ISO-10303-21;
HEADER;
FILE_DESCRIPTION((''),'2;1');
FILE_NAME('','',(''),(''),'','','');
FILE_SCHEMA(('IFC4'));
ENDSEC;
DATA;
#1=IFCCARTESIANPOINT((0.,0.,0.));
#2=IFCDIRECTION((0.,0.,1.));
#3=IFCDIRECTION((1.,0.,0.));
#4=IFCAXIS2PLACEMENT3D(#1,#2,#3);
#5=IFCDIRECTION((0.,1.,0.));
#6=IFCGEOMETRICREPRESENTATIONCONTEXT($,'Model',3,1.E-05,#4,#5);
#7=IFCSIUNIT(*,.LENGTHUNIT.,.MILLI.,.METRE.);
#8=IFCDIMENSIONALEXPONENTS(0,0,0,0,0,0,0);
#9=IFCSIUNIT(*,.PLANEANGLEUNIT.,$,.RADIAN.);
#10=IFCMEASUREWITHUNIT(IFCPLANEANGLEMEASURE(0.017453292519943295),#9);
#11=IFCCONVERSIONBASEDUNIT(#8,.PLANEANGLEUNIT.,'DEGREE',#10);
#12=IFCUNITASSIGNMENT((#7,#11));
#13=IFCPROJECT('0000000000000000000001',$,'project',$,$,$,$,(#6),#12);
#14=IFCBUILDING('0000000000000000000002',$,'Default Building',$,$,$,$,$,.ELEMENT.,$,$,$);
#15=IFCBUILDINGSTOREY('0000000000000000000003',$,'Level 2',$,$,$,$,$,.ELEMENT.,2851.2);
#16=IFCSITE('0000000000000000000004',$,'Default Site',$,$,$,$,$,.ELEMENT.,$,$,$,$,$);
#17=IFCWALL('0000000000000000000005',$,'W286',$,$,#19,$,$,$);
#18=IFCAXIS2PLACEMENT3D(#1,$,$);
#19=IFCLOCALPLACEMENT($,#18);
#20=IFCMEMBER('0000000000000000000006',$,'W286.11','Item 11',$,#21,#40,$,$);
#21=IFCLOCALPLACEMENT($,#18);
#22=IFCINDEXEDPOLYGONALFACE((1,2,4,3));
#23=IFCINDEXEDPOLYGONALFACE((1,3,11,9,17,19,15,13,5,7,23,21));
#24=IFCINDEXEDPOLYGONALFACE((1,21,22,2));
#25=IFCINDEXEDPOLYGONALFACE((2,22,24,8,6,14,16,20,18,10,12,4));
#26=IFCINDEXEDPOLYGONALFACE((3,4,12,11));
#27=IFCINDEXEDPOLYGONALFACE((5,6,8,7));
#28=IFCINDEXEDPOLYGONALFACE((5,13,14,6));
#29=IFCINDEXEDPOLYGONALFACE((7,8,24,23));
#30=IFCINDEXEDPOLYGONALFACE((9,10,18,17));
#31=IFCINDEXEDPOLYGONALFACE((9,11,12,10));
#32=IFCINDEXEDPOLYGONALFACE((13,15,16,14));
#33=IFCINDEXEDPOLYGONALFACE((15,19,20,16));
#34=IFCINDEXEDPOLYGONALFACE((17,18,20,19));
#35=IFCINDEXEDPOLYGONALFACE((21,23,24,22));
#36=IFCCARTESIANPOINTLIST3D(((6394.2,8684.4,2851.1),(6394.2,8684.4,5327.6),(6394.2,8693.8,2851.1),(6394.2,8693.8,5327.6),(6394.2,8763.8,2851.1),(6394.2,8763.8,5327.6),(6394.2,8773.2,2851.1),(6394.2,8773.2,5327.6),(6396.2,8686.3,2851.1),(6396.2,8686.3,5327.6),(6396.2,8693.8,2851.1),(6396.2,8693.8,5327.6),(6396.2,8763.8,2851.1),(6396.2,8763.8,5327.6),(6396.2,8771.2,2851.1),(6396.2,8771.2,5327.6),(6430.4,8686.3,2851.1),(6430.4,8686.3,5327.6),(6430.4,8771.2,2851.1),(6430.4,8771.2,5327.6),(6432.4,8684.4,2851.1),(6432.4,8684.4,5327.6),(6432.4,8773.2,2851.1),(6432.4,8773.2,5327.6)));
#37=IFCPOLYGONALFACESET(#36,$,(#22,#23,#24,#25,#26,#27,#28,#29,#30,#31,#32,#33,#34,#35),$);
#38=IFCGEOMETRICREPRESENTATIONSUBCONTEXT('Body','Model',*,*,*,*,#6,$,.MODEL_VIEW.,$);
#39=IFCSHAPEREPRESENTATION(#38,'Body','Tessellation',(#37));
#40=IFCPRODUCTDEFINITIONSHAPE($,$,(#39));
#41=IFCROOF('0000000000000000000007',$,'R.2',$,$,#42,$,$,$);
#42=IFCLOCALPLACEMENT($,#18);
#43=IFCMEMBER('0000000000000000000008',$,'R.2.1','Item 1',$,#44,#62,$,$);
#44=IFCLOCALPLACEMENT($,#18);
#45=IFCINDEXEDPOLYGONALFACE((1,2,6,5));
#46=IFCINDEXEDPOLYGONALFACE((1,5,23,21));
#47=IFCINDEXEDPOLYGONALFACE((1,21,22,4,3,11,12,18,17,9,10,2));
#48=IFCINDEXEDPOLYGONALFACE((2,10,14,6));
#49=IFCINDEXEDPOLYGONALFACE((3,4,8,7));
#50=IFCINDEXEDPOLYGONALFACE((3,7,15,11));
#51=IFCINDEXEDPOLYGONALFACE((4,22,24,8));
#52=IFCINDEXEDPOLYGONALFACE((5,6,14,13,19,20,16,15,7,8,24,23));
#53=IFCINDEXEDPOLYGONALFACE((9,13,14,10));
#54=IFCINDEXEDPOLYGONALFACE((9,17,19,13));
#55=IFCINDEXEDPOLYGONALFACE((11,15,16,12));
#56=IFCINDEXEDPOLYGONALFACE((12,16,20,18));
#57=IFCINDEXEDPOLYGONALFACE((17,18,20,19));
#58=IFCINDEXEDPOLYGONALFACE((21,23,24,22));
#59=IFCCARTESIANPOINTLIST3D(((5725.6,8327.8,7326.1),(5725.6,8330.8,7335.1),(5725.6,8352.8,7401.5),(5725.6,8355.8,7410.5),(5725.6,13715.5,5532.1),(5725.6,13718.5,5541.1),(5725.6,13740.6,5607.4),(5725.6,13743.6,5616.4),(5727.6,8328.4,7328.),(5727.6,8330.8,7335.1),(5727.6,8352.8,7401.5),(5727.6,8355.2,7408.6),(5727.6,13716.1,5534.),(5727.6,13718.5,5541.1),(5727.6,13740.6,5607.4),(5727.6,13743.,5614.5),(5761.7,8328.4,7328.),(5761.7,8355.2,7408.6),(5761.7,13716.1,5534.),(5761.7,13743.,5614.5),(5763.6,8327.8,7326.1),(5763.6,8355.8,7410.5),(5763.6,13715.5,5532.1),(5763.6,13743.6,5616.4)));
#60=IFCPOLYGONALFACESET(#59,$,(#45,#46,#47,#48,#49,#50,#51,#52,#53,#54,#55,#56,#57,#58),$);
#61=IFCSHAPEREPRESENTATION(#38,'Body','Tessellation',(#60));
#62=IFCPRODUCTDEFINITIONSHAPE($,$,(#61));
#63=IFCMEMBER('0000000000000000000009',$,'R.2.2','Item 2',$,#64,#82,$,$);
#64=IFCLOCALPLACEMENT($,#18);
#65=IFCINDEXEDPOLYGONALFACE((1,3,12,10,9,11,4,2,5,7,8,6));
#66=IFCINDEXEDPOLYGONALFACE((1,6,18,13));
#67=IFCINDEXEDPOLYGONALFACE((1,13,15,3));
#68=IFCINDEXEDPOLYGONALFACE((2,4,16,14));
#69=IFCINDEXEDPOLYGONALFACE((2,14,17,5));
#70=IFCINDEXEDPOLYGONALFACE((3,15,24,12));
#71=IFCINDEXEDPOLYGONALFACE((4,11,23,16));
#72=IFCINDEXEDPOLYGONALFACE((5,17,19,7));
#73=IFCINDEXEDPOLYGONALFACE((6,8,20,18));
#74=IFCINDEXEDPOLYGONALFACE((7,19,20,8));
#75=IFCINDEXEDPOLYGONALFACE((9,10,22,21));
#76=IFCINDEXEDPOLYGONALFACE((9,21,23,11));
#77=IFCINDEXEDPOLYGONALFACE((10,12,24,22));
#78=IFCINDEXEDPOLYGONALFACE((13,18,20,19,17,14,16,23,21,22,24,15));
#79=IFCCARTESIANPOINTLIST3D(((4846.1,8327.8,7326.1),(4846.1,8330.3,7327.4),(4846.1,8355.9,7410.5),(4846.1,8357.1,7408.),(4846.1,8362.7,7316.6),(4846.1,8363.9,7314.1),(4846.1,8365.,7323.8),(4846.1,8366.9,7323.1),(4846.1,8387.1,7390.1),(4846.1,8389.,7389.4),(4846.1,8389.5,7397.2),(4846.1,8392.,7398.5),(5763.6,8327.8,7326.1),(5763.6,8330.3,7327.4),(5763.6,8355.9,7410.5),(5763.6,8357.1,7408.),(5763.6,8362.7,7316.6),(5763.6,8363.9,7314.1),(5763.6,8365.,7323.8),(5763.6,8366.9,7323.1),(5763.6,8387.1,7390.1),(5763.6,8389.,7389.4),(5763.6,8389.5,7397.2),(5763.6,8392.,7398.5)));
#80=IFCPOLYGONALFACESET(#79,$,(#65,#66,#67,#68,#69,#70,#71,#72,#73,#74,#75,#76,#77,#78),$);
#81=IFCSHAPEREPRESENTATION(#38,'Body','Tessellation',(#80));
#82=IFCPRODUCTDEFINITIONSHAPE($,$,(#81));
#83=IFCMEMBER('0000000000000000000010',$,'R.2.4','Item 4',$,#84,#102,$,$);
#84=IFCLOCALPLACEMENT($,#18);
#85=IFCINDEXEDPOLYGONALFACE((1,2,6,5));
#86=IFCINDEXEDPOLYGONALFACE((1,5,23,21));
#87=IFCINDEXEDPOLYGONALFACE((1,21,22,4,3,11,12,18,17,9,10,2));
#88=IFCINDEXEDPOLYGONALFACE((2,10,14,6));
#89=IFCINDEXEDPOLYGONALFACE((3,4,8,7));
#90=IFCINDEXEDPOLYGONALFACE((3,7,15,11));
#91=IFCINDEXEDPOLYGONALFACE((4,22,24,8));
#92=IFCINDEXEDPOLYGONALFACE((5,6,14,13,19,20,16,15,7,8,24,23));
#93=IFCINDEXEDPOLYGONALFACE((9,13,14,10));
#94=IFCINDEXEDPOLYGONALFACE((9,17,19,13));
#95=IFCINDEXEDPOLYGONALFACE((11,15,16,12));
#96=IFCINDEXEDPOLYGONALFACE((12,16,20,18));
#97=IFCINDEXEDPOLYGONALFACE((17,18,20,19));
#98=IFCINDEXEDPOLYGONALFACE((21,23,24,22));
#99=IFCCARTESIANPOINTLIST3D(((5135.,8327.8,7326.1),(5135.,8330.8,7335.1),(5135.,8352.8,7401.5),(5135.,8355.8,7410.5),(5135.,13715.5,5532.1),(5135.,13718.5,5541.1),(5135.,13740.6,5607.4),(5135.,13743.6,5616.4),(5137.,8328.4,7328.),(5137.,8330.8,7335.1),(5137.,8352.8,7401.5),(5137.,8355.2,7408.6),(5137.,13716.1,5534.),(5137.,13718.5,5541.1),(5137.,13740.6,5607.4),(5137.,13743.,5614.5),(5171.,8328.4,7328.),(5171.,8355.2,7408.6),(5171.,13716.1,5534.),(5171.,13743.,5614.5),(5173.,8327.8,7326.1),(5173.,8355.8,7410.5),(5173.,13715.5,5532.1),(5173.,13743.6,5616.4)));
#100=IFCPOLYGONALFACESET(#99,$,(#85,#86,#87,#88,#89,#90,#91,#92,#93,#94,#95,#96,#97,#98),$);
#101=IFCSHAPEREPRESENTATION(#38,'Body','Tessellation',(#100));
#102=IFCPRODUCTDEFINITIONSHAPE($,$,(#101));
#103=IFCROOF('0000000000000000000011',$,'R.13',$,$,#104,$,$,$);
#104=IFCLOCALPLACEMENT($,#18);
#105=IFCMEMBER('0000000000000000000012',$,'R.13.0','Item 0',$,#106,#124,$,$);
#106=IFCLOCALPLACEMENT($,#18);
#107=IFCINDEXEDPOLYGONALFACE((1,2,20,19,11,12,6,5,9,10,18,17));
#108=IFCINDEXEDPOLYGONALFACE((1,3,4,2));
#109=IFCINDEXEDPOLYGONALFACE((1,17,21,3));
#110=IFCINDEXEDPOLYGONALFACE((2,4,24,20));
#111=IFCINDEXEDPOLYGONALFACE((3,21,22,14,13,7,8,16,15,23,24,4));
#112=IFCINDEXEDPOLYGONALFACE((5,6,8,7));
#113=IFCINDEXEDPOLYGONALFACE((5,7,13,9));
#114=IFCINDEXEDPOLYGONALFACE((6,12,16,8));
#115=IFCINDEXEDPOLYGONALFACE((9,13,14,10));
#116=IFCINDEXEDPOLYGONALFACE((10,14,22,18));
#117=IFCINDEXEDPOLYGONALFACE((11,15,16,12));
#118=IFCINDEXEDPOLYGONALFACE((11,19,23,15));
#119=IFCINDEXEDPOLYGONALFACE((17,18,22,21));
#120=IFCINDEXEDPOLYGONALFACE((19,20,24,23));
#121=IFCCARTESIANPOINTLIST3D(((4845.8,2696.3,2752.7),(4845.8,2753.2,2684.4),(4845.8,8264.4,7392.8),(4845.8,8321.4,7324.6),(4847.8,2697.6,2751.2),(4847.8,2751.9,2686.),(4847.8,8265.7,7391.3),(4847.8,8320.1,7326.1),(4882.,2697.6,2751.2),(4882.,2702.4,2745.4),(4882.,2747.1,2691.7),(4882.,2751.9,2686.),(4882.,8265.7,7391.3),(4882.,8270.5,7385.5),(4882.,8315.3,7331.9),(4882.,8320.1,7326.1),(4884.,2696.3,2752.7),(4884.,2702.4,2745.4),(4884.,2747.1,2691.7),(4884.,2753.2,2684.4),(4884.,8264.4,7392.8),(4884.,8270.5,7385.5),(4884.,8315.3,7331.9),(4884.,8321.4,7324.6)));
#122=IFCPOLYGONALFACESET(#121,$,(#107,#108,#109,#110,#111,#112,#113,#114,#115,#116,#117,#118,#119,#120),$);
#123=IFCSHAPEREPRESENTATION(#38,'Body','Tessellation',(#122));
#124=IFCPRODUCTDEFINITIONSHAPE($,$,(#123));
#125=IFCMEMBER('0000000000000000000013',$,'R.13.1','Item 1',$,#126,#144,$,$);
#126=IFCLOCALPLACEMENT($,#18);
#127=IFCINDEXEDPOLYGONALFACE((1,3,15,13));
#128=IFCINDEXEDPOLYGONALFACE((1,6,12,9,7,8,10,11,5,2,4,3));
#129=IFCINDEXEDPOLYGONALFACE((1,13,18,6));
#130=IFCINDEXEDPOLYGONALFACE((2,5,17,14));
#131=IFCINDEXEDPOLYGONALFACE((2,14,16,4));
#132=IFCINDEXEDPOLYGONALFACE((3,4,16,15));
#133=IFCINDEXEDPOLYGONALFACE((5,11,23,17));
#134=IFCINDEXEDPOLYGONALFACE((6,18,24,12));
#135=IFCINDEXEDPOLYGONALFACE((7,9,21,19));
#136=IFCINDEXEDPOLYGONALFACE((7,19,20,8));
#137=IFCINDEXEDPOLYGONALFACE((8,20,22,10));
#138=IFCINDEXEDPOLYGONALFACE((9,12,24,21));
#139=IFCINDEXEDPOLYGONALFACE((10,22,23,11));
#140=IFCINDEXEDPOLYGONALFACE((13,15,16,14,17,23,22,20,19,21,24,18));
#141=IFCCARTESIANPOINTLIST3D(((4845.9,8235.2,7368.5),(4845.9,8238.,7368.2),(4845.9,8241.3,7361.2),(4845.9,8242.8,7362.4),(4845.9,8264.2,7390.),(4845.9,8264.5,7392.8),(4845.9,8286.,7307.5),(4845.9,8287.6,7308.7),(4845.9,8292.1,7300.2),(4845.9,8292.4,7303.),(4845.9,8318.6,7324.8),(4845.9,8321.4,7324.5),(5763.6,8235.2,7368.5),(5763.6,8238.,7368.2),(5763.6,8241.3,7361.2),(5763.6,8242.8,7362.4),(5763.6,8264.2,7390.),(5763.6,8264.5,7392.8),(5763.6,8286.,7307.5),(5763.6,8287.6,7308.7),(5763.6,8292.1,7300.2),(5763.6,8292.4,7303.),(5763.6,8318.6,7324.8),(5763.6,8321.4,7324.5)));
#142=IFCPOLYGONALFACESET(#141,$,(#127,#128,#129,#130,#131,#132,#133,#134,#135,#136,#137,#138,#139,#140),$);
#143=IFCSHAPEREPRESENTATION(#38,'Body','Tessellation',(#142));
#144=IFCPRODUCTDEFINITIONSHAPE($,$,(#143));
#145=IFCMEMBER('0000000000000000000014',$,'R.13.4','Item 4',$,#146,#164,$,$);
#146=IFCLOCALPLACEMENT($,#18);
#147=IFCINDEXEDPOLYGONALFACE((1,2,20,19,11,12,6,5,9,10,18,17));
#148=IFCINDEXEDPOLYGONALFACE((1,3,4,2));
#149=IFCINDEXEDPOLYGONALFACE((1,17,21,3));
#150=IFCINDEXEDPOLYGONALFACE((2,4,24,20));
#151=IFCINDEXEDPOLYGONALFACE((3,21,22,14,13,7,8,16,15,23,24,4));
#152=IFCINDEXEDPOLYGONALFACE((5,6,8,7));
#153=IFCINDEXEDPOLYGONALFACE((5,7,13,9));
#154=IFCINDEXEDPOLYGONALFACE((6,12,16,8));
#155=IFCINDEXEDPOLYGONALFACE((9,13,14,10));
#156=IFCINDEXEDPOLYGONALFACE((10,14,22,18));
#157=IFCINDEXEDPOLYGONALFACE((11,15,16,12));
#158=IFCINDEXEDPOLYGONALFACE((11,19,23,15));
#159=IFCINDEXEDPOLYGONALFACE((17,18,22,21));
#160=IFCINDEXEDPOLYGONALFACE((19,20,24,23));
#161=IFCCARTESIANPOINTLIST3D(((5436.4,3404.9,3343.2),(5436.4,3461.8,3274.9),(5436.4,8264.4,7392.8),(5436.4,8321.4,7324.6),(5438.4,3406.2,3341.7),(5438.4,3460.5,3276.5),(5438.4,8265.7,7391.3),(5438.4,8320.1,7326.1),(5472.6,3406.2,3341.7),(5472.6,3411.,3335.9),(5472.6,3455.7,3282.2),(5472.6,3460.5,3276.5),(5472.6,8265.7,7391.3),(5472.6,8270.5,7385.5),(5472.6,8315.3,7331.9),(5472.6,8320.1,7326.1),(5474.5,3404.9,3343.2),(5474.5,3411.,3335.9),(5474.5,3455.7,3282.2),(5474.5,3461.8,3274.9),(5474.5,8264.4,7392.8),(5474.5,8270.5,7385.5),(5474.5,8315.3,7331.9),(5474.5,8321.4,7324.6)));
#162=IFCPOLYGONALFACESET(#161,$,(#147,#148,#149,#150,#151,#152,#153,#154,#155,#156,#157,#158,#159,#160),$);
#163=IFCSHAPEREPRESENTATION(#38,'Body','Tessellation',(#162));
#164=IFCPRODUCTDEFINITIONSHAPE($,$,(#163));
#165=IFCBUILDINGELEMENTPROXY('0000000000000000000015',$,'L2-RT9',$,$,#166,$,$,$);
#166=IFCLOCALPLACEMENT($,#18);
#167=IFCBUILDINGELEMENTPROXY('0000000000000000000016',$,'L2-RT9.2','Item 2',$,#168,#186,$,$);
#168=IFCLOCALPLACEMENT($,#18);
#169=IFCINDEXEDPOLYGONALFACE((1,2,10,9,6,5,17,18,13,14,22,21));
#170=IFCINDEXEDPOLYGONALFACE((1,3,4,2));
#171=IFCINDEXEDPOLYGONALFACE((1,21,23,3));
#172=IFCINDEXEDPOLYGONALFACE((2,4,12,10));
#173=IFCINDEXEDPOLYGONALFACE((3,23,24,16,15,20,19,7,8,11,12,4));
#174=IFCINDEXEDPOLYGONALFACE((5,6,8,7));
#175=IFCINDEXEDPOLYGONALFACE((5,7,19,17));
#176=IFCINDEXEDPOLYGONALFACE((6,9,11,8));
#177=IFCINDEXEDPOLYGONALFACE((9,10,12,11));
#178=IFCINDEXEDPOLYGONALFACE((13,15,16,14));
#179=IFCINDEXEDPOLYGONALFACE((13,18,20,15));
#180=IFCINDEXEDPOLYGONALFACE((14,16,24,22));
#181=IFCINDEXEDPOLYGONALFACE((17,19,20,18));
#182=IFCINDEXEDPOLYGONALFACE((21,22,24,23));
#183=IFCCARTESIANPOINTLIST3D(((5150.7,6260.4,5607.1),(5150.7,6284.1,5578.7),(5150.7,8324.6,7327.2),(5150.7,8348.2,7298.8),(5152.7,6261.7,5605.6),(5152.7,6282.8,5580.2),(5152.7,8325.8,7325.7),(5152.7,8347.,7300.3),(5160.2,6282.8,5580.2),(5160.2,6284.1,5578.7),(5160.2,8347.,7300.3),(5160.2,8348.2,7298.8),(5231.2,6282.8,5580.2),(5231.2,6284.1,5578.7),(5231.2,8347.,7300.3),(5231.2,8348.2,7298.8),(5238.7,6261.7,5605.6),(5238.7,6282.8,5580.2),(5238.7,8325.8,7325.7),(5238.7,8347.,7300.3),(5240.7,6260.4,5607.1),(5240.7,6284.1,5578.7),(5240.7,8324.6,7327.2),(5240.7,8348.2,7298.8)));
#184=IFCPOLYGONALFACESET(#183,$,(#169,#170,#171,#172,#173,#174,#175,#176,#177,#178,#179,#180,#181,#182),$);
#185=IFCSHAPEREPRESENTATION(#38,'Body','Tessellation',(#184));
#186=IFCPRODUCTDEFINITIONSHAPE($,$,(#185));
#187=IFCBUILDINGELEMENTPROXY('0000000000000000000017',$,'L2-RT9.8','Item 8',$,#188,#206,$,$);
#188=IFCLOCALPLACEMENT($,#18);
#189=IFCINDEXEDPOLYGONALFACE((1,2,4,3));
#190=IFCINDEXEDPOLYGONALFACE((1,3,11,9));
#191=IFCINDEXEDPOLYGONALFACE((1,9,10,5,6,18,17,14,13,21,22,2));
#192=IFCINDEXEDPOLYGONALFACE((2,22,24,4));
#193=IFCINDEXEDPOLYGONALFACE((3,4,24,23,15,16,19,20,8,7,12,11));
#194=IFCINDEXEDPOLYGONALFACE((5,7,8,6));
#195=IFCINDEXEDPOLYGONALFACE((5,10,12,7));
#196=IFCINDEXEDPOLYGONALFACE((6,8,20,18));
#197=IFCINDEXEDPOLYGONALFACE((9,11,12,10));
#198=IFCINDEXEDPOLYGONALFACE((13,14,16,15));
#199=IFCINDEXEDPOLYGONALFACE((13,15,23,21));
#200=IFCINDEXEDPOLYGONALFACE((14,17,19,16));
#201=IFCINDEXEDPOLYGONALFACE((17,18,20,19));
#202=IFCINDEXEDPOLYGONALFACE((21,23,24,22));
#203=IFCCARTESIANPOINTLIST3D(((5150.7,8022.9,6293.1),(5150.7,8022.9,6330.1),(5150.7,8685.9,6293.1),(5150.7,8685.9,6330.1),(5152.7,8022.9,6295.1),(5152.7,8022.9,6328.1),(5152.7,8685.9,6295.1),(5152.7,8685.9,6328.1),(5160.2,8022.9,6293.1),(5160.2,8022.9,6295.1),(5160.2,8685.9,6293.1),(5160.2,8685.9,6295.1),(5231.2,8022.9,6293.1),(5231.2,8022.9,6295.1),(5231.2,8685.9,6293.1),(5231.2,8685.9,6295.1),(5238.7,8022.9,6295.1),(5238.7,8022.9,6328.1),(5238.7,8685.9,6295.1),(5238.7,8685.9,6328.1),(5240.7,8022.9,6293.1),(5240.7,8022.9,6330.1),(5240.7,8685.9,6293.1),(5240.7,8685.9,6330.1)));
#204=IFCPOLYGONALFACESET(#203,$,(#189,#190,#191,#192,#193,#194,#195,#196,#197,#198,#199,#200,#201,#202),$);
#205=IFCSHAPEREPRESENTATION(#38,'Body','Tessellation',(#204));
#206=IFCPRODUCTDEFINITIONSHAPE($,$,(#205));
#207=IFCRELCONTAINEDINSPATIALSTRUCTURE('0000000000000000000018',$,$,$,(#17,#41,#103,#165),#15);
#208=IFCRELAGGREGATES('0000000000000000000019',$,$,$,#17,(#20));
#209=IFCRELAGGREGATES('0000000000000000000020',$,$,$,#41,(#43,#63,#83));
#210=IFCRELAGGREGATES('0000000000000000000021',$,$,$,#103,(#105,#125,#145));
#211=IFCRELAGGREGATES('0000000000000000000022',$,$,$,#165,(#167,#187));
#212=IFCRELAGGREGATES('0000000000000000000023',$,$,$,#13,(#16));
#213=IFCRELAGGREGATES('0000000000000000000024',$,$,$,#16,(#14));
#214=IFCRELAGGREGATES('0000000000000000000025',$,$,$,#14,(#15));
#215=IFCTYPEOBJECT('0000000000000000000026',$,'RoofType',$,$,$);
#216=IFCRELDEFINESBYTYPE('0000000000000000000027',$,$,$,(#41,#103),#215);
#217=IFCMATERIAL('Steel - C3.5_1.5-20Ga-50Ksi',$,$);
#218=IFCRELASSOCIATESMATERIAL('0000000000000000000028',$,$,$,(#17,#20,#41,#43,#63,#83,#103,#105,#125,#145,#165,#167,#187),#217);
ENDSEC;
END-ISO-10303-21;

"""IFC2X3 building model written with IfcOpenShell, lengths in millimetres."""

from ifc_helpers import new_model, entity, si_unit, converted_unit, direction, frame, origin, origin_with_axes, origin_2d_with_axis, place, context, subcontext, project, spatial, c_section, extrude, material, type_object, element, aggregate, save


model = new_model("IFC2X3")

# Units and contexts
model_context = context("Model", 3, precision=1e-05, world=origin_with_axes(), true_north=direction((0.0, 1.0, 0.0)))
body_context = subcontext(model_context, "Body", "Model", "MODEL_VIEW")
ifc_project = project(units=[si_unit("LENGTHUNIT", "METRE", prefix="MILLI"), converted_unit("PLANEANGLEUNIT", "DEGREE", entity("IfcPlaneAngleMeasure", 0.017453292519943295), si_unit("PLANEANGLEUNIT", "RADIAN"), dimensions=[0, 0, 0, 0, 0, 0, 0])], contexts=[model_context])

# Site, building, storey
site = spatial("IfcSite", under=ifc_project, Name="Default Site", CompositionType="ELEMENT")
building = spatial("IfcBuilding", under=site, Name="Default Building", CompositionType="ELEMENT")
storey = spatial("IfcBuildingStorey", under=building, Name="Level 2", CompositionType="ELEMENT", Elevation=2851.2)

# Wall, member
ifc_material_1 = material(Name="Steel - C3.5_1.5-20Ga-50Ksi")
wall = element("IfcWall", 1, inside=storey, material=ifc_material_1, Name="W286")
member_1_placement = place(None, frame((6413.3, 8728.8, 5327.6), z_axis=(0.0, 0.0, -1.0), x_axis=(-1.0, 0.0, 0.0)))
member_1 = element("IfcMember", 2, at=member_1_placement, material=ifc_material_1, Name="W286.11", Description="Item 11", context=body_context, shape_type="SweptSolid", body=[
    extrude(c_section(Depth=88.9, Width=38.1, WallThickness=2.0, Girth=9.5, at=origin_2d_with_axis()), origin(), (0.0, 0.0, 1.0), 2476.5),
])
aggregate(wall, [member_1])

# Roofs, members
ifc_type_object = type_object("IfcTypeObject", Name="RoofType")
roof_1 = element("IfcRoof", 3, inside=storey, type_object=ifc_type_object, material=ifc_material_1, Name="R.2")
member_2_placement = place(None, frame((5744.6, 8341.8, 7368.3), z_axis=(0.0, 0.949, -0.316), x_axis=(-1.0, 0.0, 0.0)))
member_2 = element("IfcMember", 4, at=member_2_placement, material=ifc_material_1, Name="R.2.1", Description="Item 1", context=body_context, shape_type="SweptSolid", body=[
    extrude(c_section(Depth=88.9, Width=38.1, WallThickness=2.0, Girth=9.5, at=origin_2d_with_axis()), origin(), (0.0, 0.0, 1.0), 5678.6),
])
member_3_placement = place(None, frame((4846.1, 8359.9, 7362.3), z_axis=(1.0, 0.0, 0.0), x_axis=(0.0, 0.949, -0.316)))
member_3 = element("IfcMember", 5, at=member_3_placement, material=ifc_material_1, Name="R.2.2", Description="Item 2", context=body_context, shape_type="SweptSolid", body=[
    extrude(c_section(Depth=88.9, Width=38.1, WallThickness=2.0, Girth=9.5, at=origin_2d_with_axis()), origin(), (0.0, 0.0, 1.0), 917.5),
])
member_4_placement = place(None, frame((5154.0, 8341.8, 7368.3), z_axis=(0.0, 0.949, -0.316), x_axis=(-1.0, 0.0, 0.0)))
member_4 = element("IfcMember", 6, at=member_4_placement, material=ifc_material_1, Name="R.2.4", Description="Item 4", context=body_context, shape_type="SweptSolid", body=[
    extrude(c_section(Depth=88.9, Width=38.1, WallThickness=2.0, Girth=9.5, at=origin_2d_with_axis()), origin(), (0.0, 0.0, 1.0), 5678.6),
])
aggregate(roof_1, [member_2, member_3, member_4])
roof_2 = element("IfcRoof", 7, inside=storey, type_object=ifc_type_object, material=ifc_material_1, Name="R.13")
member_5_placement = place(None, frame((4864.9, 8292.9, 7358.7), z_axis=(0.0, -0.768, -0.64), x_axis=(1.0, 0.0, 0.0)))
member_5 = element("IfcMember", 8, at=member_5_placement, material=ifc_material_1, Name="R.13.0", Description="Item 0", context=body_context, shape_type="SweptSolid", body=[
    extrude(c_section(Depth=88.9, Width=38.1, WallThickness=2.0, Girth=9.5, at=origin_2d_with_axis()), origin(), (0.0, 0.0, 1.0), 7248.1),
])
member_6_placement = place(None, frame((5763.6, 8278.3, 7346.5), z_axis=(-1.0, 0.0, 0.0), x_axis=(0.0, -0.768, -0.64)))
member_6 = element("IfcMember", 9, at=member_6_placement, material=ifc_material_1, Name="R.13.1", Description="Item 1", context=body_context, shape_type="SweptSolid", body=[
    extrude(c_section(Depth=88.9, Width=38.1, WallThickness=2.0, Girth=9.5, at=origin_2d_with_axis()), origin(), (0.0, 0.0, 1.0), 917.7),
])
member_7_placement = place(None, frame((5455.5, 8292.9, 7358.7), z_axis=(0.0, -0.768, -0.64), x_axis=(1.0, 0.0, 0.0)))
member_7 = element("IfcMember", 10, at=member_7_placement, material=ifc_material_1, Name="R.13.4", Description="Item 4", context=body_context, shape_type="SweptSolid", body=[
    extrude(c_section(Depth=88.9, Width=38.1, WallThickness=2.0, Girth=9.5, at=origin_2d_with_axis()), origin(), (0.0, 0.0, 1.0), 6325.7),
])
aggregate(roof_2, [member_5, member_6, member_7])

# Building element proxies
proxy_1 = element("IfcBuildingElementProxy", 11, inside=storey, material=ifc_material_1, Name="L2-RT9")
proxy_2_placement = place(None, frame((5195.7, 8336.4, 7313.0), z_axis=(0.0, -0.768, -0.64), x_axis=(0.0, 23.689, -28.422)))
proxy_2 = element("IfcBuildingElementProxy", 12, at=proxy_2_placement, material=ifc_material_1, Name="L2-RT9.2", Description="Item 2", context=body_context, shape_type="SweptSolid", body=[
    extrude(c_section(Depth=90.0, Width=37.0, WallThickness=2.0, Girth=9.5, at=origin_2d_with_axis()), origin(), (0.0, 0.0, 1.0), 2686.9),
])
proxy_3_placement = place(None, frame((5195.7, 8685.9, 6311.6), z_axis=(0.0, -1.0, 0.0), x_axis=(0.0, -0.001, -37.0)))
proxy_3 = element("IfcBuildingElementProxy", 13, at=proxy_3_placement, material=ifc_material_1, Name="L2-RT9.8", Description="Item 8", context=body_context, shape_type="SweptSolid", body=[
    extrude(c_section(Depth=90.0, Width=37.0, WallThickness=2.0, Girth=9.5, at=origin_2d_with_axis()), origin(), (0.0, 0.0, 1.0), 663.0),
])
aggregate(proxy_1, [proxy_2, proxy_3])

save(model, "model.ifc")
